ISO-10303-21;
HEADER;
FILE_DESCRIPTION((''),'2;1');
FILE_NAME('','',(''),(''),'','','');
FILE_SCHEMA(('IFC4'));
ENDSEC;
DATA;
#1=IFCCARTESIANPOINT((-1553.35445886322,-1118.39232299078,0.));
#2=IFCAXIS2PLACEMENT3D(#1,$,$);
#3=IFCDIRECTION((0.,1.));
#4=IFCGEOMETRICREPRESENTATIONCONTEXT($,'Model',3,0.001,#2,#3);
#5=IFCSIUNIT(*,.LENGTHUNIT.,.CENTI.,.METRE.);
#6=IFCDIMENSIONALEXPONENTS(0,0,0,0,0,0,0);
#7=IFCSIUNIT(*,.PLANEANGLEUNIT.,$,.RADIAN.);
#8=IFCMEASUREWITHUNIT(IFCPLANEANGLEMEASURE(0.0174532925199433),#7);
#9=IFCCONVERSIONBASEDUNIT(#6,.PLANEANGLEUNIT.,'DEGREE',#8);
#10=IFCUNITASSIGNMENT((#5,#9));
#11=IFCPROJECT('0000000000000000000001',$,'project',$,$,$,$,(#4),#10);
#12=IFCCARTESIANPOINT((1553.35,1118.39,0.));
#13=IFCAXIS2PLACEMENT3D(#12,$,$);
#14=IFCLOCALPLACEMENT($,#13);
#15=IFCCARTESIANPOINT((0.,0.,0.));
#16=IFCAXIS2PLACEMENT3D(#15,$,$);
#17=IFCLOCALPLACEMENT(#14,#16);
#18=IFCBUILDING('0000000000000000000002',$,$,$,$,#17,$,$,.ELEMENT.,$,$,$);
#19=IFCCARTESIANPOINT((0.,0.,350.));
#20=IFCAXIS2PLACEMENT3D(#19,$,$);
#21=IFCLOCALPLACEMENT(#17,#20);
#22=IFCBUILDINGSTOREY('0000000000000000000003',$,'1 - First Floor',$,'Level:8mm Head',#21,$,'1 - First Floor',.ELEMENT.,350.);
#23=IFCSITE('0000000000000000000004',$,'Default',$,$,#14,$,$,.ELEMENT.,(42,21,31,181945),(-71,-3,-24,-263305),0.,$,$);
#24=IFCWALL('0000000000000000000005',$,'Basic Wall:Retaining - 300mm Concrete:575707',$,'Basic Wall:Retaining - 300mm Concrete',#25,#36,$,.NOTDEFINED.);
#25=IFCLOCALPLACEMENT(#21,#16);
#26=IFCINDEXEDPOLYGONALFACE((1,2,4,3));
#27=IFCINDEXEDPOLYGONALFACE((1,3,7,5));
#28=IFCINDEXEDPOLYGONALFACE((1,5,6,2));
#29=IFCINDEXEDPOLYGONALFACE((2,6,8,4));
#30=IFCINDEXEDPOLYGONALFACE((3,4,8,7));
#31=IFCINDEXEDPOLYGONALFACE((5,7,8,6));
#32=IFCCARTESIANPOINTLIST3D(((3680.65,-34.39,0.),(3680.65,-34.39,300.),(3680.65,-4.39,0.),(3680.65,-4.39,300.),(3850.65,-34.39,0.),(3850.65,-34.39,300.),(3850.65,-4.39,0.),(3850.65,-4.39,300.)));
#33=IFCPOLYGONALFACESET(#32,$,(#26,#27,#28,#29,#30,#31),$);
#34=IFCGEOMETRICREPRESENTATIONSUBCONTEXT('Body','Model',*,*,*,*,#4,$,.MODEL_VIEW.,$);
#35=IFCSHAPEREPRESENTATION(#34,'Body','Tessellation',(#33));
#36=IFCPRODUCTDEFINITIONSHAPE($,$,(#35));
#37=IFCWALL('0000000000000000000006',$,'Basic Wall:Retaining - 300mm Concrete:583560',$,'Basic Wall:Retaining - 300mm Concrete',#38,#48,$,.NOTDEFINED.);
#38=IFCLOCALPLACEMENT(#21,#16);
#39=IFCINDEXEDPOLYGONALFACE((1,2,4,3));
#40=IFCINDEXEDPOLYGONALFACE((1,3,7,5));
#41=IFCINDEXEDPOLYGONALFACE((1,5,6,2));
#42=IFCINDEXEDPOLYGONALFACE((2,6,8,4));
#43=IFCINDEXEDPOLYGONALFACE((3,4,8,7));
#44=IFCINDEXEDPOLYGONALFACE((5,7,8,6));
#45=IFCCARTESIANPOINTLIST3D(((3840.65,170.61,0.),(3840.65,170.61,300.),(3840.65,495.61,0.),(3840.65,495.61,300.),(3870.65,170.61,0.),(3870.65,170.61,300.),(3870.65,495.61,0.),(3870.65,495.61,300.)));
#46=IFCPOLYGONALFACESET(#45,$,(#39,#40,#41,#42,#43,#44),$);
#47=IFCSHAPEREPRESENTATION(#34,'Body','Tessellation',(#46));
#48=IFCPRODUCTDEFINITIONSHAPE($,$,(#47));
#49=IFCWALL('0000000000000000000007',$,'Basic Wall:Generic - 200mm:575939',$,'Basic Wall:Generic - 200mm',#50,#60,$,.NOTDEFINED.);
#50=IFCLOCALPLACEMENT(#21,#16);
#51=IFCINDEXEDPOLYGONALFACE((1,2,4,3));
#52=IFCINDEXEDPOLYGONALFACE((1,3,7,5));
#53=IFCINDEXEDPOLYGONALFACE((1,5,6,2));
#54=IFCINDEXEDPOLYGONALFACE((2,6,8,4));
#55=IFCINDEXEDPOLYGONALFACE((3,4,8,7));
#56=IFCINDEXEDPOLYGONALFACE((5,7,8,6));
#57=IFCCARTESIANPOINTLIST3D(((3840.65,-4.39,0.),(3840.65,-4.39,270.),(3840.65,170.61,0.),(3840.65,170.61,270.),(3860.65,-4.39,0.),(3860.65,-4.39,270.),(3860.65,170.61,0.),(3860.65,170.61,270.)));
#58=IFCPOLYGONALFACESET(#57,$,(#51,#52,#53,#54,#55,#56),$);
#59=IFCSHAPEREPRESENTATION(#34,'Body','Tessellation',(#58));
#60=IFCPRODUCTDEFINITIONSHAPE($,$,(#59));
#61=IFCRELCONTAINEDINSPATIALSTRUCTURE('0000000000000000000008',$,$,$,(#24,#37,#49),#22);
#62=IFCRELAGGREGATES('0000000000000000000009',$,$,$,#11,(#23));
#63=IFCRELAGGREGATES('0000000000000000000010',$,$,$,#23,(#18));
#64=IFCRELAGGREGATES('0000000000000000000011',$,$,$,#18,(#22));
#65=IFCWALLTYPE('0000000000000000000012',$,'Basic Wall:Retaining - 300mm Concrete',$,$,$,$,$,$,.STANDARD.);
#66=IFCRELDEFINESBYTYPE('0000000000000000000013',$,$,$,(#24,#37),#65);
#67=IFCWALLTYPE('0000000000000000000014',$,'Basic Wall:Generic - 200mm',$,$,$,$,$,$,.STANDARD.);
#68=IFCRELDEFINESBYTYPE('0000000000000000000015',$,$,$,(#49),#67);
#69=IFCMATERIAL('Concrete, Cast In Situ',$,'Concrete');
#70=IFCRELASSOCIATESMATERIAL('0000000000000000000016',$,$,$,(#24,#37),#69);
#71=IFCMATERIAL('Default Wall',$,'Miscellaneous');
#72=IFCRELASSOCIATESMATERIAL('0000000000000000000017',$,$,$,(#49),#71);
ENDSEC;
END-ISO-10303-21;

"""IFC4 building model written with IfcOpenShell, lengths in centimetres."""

from ifc_helpers import new_model, entity, si_unit, converted_unit, direction, frame, origin, place, context, subcontext, project, spatial, indexed_curve, outline, extrude, material, type_object, element, save


model = new_model("IFC4")

# Units and contexts
model_context = context("Model", 3, precision=0.001, world=frame((-1553.35445886322, -1118.39232299078, 0.0)), true_north=direction((0.0, 1.0)))
body_context = subcontext(model_context, "Body", "Model", "MODEL_VIEW")
ifc_project = project(units=[si_unit("LENGTHUNIT", "METRE", prefix="CENTI"), converted_unit("PLANEANGLEUNIT", "DEGREE", entity("IfcPlaneAngleMeasure", 0.0174532925199433), si_unit("PLANEANGLEUNIT", "RADIAN"), dimensions=[0, 0, 0, 0, 0, 0, 0])], contexts=[model_context])

# Site, building, storey
site_placement = place(None, frame((1553.35, 1118.39, 0.0)))
site = spatial("IfcSite", under=ifc_project, at=site_placement, Name="Default", CompositionType="ELEMENT", RefLatitude=(42, 21, 31, 181945), RefLongitude=(-71, -3, -24, -263305), RefElevation=0.0)
building_placement = place(site_placement, origin())
building = spatial("IfcBuilding", under=site, at=building_placement, CompositionType="ELEMENT")
storey_placement = place(building_placement, frame((0.0, 0.0, 350.0)))
storey = spatial("IfcBuildingStorey", under=building, at=storey_placement, Name="1 - First Floor", ObjectType="Level:8mm Head", LongName="1 - First Floor", CompositionType="ELEMENT", Elevation=350.0)

# Walls
ifc_material_1 = material(Name="Concrete, Cast In Situ", Category="Concrete")
wall_type_1 = type_object("IfcWallType", Name="Basic Wall:Retaining - 300mm Concrete", PredefinedType="STANDARD")
wall_1_placement = place(storey_placement, frame((3850.65, -19.39, 0.0), z_axis=(0.0, 0.0, 1.0), x_axis=(-1.0, 0.0, 0.0)))
element("IfcWall", 1, at=wall_1_placement, inside=storey, type_object=wall_type_1, material=ifc_material_1, Name="Basic Wall:Retaining - 300mm Concrete:575707", ObjectType="Basic Wall:Retaining - 300mm Concrete", PredefinedType="NOTDEFINED", context=body_context, shape_type="SweptSolid", body=[
    extrude(outline(indexed_curve([(170.0, 15.0), (0.0, 15.0), (0.0, -15.0), (170.0, -15.0), (170.0, 15.0)], self_intersect=False)), origin(), (0.0, 0.0, 1.0), 300.0),
])
wall_2_placement = place(storey_placement, frame((3855.65, 495.61, 0.0), z_axis=(0.0, 0.0, 1.0), x_axis=(0.0, -1.0, 0.0)))
element("IfcWall", 2, at=wall_2_placement, inside=storey, type_object=wall_type_1, material=ifc_material_1, Name="Basic Wall:Retaining - 300mm Concrete:583560", ObjectType="Basic Wall:Retaining - 300mm Concrete", PredefinedType="NOTDEFINED", context=body_context, shape_type="SweptSolid", body=[
    extrude(outline(indexed_curve([(325.0, 15.0), (0.0, 15.0), (0.0, -15.0), (325.0, -15.0), (325.0, 15.0)], self_intersect=False)), origin(), (0.0, 0.0, 1.0), 300.0),
])
ifc_material_2 = material(Name="Default Wall", Category="Miscellaneous")
wall_type_2 = type_object("IfcWallType", Name="Basic Wall:Generic - 200mm", PredefinedType="STANDARD")
wall_3_placement = place(storey_placement, frame((3850.65, 170.61, 0.0), z_axis=(0.0, 0.0, 1.0), x_axis=(0.0, -1.0, 0.0)))
element("IfcWall", 3, at=wall_3_placement, inside=storey, type_object=wall_type_2, material=ifc_material_2, Name="Basic Wall:Generic - 200mm:575939", ObjectType="Basic Wall:Generic - 200mm", PredefinedType="NOTDEFINED", context=body_context, shape_type="SweptSolid", body=[
    extrude(outline(indexed_curve([(175.0, 10.0), (0.0, 10.0), (0.0, -10.0), (175.0, -10.0), (175.0, 10.0)], self_intersect=False)), origin(), (0.0, 0.0, 1.0), 270.0),
])

save(model, "model.ifc")
